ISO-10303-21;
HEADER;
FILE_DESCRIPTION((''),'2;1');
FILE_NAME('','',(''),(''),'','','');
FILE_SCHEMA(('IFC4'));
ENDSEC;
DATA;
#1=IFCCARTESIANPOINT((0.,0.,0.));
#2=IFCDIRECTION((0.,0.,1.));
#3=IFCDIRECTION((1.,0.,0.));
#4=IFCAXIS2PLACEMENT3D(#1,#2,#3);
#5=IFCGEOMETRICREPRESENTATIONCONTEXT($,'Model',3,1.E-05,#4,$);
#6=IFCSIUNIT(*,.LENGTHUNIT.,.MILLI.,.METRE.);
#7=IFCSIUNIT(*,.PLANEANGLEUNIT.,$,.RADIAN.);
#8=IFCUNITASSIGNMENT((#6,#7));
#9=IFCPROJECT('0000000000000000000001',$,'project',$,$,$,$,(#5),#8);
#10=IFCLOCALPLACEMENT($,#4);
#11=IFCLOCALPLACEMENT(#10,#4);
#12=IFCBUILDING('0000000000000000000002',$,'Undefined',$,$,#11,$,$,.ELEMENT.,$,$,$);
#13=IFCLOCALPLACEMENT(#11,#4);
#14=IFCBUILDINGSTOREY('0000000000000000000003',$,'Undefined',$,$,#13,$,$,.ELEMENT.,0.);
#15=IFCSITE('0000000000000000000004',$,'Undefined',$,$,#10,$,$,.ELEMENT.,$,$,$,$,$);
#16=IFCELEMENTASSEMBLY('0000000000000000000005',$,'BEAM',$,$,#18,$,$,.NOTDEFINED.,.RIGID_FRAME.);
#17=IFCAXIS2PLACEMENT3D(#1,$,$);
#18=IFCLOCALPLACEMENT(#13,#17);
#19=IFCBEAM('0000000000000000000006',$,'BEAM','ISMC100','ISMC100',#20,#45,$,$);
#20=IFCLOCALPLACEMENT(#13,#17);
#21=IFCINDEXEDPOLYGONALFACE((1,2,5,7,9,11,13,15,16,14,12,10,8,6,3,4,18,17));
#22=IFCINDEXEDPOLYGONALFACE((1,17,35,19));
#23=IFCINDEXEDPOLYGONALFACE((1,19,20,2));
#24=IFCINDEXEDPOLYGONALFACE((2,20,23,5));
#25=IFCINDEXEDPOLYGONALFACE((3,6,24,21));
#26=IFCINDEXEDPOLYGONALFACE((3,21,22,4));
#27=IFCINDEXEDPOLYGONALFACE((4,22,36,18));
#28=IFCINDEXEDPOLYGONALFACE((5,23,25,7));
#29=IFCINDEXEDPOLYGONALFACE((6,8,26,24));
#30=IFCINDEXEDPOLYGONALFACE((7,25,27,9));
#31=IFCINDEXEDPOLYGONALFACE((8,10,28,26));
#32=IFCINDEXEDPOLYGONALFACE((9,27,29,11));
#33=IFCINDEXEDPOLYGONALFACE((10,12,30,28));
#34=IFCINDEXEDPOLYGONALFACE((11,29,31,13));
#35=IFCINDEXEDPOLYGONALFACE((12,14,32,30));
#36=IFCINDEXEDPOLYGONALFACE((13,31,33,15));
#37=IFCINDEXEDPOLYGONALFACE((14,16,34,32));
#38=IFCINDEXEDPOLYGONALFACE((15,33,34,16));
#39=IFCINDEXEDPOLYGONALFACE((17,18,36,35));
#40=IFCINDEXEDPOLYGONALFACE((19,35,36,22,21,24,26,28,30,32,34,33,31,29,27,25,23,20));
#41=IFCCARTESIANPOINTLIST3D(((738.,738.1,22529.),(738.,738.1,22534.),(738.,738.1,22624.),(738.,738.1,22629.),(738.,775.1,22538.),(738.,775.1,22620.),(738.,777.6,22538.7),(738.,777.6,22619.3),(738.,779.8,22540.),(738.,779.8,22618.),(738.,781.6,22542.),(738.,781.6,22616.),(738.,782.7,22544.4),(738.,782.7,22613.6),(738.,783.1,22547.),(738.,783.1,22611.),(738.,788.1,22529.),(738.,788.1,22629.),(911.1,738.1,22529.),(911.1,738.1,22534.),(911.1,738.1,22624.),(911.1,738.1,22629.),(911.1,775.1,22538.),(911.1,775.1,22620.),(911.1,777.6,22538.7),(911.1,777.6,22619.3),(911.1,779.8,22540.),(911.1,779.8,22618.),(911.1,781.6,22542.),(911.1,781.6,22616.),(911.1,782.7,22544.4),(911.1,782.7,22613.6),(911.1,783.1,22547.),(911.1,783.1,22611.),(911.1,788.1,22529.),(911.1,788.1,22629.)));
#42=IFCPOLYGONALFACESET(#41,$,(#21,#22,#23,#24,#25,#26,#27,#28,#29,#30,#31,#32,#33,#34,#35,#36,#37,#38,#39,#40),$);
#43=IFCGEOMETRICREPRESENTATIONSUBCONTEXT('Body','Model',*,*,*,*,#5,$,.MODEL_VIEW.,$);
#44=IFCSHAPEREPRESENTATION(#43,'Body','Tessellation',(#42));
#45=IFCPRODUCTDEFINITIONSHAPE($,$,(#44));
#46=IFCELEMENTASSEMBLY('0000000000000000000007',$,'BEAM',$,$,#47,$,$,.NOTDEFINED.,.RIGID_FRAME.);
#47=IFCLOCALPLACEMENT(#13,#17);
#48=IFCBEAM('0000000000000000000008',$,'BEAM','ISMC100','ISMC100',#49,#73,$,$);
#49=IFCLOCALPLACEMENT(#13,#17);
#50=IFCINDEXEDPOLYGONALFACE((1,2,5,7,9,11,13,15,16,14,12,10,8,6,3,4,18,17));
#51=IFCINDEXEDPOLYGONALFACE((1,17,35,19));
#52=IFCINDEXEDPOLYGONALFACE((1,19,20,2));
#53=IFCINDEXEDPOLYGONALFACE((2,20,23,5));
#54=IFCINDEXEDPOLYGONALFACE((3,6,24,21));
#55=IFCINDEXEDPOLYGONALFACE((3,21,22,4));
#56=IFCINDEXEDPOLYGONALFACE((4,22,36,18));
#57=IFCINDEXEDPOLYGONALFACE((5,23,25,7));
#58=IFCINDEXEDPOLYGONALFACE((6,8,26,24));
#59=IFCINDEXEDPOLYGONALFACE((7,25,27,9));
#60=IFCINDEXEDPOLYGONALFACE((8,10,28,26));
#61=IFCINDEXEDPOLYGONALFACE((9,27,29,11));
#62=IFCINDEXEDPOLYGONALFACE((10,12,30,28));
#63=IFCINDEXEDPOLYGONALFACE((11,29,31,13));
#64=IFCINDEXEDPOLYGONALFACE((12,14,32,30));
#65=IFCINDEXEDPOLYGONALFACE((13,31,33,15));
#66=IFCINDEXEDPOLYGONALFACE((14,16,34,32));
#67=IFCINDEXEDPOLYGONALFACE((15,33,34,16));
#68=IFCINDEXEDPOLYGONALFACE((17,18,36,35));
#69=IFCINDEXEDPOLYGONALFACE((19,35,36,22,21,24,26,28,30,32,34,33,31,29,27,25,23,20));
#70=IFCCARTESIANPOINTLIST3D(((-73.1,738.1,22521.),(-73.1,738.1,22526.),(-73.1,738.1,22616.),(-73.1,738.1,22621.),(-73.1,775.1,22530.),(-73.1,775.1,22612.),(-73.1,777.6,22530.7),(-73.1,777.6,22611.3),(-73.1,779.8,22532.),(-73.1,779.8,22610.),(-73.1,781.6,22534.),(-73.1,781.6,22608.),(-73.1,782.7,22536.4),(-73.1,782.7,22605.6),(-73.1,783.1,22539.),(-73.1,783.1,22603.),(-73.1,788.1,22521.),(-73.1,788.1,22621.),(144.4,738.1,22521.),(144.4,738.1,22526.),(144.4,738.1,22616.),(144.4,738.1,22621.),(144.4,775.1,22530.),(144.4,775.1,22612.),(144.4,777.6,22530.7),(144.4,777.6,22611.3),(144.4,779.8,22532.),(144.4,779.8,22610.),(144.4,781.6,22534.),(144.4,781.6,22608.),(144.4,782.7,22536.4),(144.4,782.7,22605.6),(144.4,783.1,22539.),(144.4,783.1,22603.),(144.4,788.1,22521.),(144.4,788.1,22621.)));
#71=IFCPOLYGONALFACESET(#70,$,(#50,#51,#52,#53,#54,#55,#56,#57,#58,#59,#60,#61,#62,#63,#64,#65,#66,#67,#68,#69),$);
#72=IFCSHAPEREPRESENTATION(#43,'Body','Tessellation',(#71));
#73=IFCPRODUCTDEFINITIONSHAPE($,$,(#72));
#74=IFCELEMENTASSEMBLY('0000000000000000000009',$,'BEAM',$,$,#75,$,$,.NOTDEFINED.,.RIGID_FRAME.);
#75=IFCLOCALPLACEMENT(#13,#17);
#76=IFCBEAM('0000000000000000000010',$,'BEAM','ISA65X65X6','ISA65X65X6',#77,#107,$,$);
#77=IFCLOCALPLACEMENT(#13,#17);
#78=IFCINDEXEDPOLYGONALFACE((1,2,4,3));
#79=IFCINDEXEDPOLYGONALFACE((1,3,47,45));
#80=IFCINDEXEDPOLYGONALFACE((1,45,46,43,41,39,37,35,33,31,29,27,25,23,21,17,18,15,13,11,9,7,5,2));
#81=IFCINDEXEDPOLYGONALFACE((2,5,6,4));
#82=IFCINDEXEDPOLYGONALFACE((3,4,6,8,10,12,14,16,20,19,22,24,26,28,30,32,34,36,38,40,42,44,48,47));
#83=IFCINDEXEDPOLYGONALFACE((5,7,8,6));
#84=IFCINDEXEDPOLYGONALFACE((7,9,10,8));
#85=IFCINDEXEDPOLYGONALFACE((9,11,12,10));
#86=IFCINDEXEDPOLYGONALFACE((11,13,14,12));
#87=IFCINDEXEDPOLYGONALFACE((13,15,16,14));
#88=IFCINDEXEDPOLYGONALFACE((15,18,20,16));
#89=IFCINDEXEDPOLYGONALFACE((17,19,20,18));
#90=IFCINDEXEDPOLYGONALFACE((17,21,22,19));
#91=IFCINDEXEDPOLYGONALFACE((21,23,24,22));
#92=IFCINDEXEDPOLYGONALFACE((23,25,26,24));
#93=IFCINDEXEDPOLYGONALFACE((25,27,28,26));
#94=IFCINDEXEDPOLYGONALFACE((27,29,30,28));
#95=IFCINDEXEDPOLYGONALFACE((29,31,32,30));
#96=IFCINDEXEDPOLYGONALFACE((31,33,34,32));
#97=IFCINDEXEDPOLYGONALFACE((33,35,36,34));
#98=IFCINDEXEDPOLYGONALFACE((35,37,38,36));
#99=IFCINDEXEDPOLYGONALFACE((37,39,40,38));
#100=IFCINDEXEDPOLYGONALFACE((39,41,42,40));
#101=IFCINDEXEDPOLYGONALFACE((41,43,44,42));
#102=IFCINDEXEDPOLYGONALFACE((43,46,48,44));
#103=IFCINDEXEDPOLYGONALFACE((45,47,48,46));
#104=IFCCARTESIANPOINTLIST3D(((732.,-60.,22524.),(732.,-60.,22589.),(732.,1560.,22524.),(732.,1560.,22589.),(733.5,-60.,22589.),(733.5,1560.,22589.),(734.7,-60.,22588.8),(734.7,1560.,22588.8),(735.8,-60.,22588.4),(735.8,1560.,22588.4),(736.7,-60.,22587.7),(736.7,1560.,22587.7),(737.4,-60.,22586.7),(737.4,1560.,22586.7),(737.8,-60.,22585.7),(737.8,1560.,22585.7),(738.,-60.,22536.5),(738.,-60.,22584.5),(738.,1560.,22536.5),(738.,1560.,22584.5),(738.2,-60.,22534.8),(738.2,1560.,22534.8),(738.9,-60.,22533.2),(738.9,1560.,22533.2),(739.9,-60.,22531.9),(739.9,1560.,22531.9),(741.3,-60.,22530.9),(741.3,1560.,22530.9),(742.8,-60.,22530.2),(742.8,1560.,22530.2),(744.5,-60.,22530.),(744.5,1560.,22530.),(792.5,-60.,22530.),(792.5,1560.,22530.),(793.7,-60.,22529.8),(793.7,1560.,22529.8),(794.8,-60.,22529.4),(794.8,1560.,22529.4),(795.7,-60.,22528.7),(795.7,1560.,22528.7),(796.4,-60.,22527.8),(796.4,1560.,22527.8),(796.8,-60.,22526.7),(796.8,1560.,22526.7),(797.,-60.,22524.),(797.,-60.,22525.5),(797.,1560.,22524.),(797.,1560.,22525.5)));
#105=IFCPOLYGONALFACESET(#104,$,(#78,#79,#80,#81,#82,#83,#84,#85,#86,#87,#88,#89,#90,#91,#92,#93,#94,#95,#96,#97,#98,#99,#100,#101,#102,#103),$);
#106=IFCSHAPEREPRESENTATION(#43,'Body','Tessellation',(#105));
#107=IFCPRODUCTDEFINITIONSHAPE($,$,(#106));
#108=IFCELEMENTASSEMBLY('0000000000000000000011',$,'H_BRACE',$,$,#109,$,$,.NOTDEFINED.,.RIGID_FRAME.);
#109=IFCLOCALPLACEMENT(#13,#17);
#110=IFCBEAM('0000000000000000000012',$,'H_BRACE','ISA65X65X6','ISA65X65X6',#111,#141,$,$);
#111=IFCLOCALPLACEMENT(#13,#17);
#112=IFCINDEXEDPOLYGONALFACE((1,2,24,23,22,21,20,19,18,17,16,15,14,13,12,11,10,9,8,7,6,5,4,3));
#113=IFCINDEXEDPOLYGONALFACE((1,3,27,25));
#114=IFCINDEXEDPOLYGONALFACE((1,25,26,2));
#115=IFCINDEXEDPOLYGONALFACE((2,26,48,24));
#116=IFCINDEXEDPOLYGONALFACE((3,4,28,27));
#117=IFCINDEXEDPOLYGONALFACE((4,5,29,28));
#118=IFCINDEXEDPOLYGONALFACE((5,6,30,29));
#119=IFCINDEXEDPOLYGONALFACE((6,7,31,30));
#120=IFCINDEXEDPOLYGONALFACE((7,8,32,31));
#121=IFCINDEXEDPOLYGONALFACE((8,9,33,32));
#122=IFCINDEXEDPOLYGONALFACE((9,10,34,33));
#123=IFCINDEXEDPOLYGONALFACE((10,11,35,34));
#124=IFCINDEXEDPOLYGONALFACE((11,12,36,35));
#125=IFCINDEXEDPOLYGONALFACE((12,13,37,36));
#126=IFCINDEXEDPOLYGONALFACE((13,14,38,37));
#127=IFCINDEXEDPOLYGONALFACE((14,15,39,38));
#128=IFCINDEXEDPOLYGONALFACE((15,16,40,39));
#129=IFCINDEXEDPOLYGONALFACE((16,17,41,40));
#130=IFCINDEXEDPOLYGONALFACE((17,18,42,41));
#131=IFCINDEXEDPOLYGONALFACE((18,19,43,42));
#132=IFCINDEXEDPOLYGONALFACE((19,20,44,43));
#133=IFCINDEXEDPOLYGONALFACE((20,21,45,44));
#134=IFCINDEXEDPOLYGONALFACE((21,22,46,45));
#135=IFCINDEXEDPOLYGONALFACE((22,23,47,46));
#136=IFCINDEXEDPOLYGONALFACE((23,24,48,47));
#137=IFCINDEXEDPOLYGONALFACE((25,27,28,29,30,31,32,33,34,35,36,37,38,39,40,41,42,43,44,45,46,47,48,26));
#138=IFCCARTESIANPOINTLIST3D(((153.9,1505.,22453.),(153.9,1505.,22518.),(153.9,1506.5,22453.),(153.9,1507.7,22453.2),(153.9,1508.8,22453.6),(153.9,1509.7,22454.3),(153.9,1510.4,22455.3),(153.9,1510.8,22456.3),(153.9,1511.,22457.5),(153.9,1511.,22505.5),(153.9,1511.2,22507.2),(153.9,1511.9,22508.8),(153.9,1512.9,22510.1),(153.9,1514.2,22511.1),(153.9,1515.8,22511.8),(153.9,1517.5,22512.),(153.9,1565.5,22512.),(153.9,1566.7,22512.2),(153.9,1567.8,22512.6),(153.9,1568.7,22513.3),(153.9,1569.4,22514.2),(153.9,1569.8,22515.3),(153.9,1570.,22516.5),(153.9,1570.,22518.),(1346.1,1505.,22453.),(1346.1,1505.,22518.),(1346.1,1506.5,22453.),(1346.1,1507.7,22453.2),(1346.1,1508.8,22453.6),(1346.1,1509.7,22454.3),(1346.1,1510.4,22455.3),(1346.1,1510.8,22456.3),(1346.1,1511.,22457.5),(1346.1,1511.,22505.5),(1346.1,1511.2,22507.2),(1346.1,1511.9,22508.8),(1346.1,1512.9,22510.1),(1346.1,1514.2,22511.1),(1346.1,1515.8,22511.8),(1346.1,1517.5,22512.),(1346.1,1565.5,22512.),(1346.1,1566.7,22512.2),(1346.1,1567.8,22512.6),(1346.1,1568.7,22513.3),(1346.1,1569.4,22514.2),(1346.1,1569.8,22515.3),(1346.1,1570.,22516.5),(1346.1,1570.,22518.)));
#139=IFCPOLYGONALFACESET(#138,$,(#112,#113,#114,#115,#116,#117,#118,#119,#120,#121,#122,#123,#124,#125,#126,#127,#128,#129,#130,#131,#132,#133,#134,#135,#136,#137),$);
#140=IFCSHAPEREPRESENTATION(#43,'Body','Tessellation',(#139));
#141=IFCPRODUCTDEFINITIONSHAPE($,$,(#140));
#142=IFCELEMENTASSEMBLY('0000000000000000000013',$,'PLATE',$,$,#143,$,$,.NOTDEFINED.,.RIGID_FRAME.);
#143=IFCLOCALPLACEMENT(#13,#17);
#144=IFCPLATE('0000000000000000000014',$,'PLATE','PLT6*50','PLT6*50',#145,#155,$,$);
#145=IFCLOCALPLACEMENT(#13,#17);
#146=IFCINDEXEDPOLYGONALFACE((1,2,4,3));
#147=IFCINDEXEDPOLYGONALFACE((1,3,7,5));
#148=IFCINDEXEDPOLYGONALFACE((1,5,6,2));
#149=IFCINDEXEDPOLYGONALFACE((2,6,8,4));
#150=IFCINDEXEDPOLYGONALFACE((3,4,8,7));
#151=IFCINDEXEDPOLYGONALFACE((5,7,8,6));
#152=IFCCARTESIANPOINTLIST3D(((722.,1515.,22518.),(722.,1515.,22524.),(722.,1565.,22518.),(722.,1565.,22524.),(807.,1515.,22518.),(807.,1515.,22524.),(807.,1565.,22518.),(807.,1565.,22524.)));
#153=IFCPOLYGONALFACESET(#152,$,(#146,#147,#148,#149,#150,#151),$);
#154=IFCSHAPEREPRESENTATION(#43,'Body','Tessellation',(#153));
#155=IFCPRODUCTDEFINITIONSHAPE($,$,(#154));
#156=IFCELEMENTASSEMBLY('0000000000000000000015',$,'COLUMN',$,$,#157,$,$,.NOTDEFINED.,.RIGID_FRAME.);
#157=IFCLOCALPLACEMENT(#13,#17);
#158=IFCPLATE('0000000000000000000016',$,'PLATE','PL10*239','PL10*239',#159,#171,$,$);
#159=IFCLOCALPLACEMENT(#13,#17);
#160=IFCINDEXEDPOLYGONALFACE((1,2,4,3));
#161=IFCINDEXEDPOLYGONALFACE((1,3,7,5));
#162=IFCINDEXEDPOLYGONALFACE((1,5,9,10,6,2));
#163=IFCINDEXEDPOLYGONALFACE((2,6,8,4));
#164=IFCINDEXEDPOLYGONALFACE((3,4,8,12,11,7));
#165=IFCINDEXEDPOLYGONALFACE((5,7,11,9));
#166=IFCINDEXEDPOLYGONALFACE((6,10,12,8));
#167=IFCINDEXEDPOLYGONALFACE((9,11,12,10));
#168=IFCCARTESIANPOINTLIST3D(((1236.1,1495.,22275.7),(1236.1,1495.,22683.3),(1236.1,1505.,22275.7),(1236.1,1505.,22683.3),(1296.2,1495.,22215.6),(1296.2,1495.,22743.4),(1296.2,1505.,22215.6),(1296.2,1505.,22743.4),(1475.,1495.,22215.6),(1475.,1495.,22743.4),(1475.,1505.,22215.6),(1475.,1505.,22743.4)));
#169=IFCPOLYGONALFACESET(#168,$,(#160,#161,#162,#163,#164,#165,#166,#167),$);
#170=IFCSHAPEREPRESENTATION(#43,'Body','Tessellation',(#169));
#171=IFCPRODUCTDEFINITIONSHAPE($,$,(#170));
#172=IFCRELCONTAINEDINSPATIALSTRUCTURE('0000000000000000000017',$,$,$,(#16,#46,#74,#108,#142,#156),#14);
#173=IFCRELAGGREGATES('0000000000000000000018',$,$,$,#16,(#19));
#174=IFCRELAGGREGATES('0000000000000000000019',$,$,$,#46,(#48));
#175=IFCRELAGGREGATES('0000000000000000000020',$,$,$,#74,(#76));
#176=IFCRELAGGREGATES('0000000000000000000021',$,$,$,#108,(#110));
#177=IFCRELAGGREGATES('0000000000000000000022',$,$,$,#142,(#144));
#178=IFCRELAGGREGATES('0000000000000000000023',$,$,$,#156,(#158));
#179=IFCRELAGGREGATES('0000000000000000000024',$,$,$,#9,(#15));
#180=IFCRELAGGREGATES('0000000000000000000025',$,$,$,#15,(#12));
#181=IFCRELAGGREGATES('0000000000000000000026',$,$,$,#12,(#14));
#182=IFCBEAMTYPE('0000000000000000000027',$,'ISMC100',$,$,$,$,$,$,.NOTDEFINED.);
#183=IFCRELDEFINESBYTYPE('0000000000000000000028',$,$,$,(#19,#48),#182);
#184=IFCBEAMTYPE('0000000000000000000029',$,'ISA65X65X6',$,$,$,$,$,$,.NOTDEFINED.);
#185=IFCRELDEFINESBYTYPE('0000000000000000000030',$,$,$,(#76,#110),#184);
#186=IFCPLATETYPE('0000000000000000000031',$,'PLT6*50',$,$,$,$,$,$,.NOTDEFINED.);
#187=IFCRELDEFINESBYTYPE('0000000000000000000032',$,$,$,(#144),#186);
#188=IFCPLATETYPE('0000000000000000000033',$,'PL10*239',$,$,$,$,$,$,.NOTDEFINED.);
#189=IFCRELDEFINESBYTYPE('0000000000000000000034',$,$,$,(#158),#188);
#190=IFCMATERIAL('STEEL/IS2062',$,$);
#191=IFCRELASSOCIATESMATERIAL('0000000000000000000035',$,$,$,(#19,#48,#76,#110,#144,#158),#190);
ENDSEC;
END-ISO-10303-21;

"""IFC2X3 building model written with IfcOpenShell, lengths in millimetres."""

from ifc_helpers import new_model, si_unit, frame, origin_with_axes, origin_2d_with_axis, place, context, subcontext, project, spatial, polyline, l_section, u_section, outline, extrude, clip, halfspace, material, type_object, element, aggregate, save


model = new_model("IFC2X3")

# Units and contexts
model_context = context("Model", 3, precision=1e-05, world=origin_with_axes())
body_context = subcontext(model_context, "Body", "Model", "MODEL_VIEW")
ifc_project = project(units=[si_unit("LENGTHUNIT", "METRE", prefix="MILLI"), si_unit("PLANEANGLEUNIT", "RADIAN")], contexts=[model_context])

# Site, building, storey
site_placement = place(None, origin_with_axes())
site = spatial("IfcSite", under=ifc_project, at=site_placement, Name="Undefined", CompositionType="ELEMENT")
building_placement = place(site_placement, origin_with_axes())
building = spatial("IfcBuilding", under=site, at=building_placement, Name="Undefined", CompositionType="ELEMENT")
storey_placement = place(building_placement, origin_with_axes())
storey = spatial("IfcBuildingStorey", under=building, at=storey_placement, Name="Undefined", CompositionType="ELEMENT", Elevation=0.0)

# Shared definitions
ifc_material = material(Name="STEEL/IS2062")

# Element assemblies, beams
beam_type_1 = type_object("IfcBeamType", Name="ISMC100", PredefinedType="NOTDEFINED")
assembly_1_placement = place(storey_placement, origin_with_axes())
assembly_1 = element("IfcElementAssembly", 1, at=assembly_1_placement, inside=storey, Name="BEAM", AssemblyPlace="NOTDEFINED", PredefinedType="RIGID_FRAME")
beam_1_placement = place(assembly_1_placement, frame((911.1, 763.1, 22579.0), z_axis=(0.0, 0.0, -1.0), x_axis=(-1.0, 0.0, 0.0)))
beam_1 = element("IfcBeam", 2, at=beam_1_placement, type_object=beam_type_1, material=ifc_material, Name="BEAM", Description="ISMC100", ObjectType="ISMC100", context=body_context, shape_type="SweptSolid", body=[
    extrude(u_section(Depth=100.0, FlangeWidth=50.0, WebThickness=5.0, FlangeThickness=7.7, FilletRadius=9.0, FlangeSlope=0.10956, at=origin_2d_with_axis()), frame((173.1, 0.0, 0.0), z_axis=(-1.0, 0.0, 0.0), x_axis=(0.0, -1.0, 0.0)), (0.0, 0.0, 1.0), 173.1),
])
aggregate(assembly_1, [beam_1])
assembly_2_placement = place(storey_placement, origin_with_axes())
assembly_2 = element("IfcElementAssembly", 3, at=assembly_2_placement, inside=storey, Name="BEAM", AssemblyPlace="NOTDEFINED", PredefinedType="RIGID_FRAME")
beam_2_placement = place(assembly_2_placement, frame((144.4, 763.1, 22571.0), z_axis=(0.0, 0.0, -1.0), x_axis=(-1.0, 0.0, 0.0)))
beam_2 = element("IfcBeam", 4, at=beam_2_placement, type_object=beam_type_1, material=ifc_material, Name="BEAM", Description="ISMC100", ObjectType="ISMC100", context=body_context, shape_type="SweptSolid", body=[
    extrude(u_section(Depth=100.0, FlangeWidth=50.0, WebThickness=5.0, FlangeThickness=7.7, FilletRadius=9.0, FlangeSlope=0.10956, at=origin_2d_with_axis()), frame((217.6, 0.0, 0.0), z_axis=(-1.0, 0.0, 0.0), x_axis=(0.0, -1.0, 0.0)), (0.0, 0.0, 1.0), 217.6),
])
aggregate(assembly_2, [beam_2])
assembly_3_placement = place(storey_placement, origin_with_axes())
assembly_3 = element("IfcElementAssembly", 5, at=assembly_3_placement, inside=storey, Name="BEAM", AssemblyPlace="NOTDEFINED", PredefinedType="RIGID_FRAME")
beam_type_2 = type_object("IfcBeamType", Name="ISA65X65X6", PredefinedType="NOTDEFINED")
beam_3_placement = place(assembly_3_placement, frame((764.5, 1560.0, 22556.5), z_axis=(1.0, 0.0, 0.0), x_axis=(0.0, -1.0, 0.0)))
beam_3 = element("IfcBeam", 6, at=beam_3_placement, type_object=beam_type_2, material=ifc_material, Name="BEAM", Description="ISA65X65X6", ObjectType="ISA65X65X6", context=body_context, shape_type="SweptSolid", body=[
    extrude(l_section(Depth=65.0, Width=65.0, Thickness=6.0, FilletRadius=6.5, EdgeRadius=4.5, at=origin_2d_with_axis()), frame((1620.0, 0.0, 0.0), z_axis=(-1.0, 0.0, 0.0), x_axis=(0.0, -1.0, 0.0)), (0.0, 0.0, 1.0), 1620.0),
])
aggregate(assembly_3, [beam_3])
assembly_4_placement = place(storey_placement, origin_with_axes())
assembly_4 = element("IfcElementAssembly", 7, at=assembly_4_placement, inside=storey, Name="H_BRACE", AssemblyPlace="NOTDEFINED", PredefinedType="RIGID_FRAME")
beam_4_placement = place(assembly_4_placement, frame((1500.0, 1537.5, 22485.5), z_axis=(0.0, 1.0, 0.0), x_axis=(-1.0, 0.0, 0.0)))
beam_4 = element("IfcBeam", 8, at=beam_4_placement, type_object=beam_type_2, material=ifc_material, Name="H_BRACE", Description="ISA65X65X6", ObjectType="ISA65X65X6", context=body_context, shape_type="Clipping", body=[
    clip(clip(extrude(l_section(Depth=65.0, Width=65.0, Thickness=6.0, FilletRadius=6.5, EdgeRadius=4.5, at=origin_2d_with_axis()), frame((1500.0, 0.0, 0.0), z_axis=(-1.0, 0.0, 0.0), x_axis=(0.0, -1.0, 0.0)), (0.0, 0.0, 1.0), 1500.0), halfspace(frame((1346.1, 0.0, -42.5), z_axis=(-1.0, 0.0, 0.0), x_axis=(0.0, 1.0, 0.0)), True)), halfspace(frame((153.9, 0.0, -42.5), z_axis=(1.0, 0.0, 0.0), x_axis=(0.0, -1.0, 0.0)), True)),
])
aggregate(assembly_4, [beam_4])

# Element assemblies, plates
assembly_5_placement = place(storey_placement, origin_with_axes())
assembly_5 = element("IfcElementAssembly", 9, at=assembly_5_placement, inside=storey, Name="PLATE", AssemblyPlace="NOTDEFINED", PredefinedType="RIGID_FRAME")
plate_type_1 = type_object("IfcPlateType", Name="PLT6*50", PredefinedType="NOTDEFINED")
plate_1_placement = place(assembly_5_placement, frame((807.0, 1565.0, 22521.0), z_axis=(0.0, 0.0, 1.0), x_axis=(-1.0, 0.0, 0.0)))
plate_1 = element("IfcPlate", 10, at=plate_1_placement, type_object=plate_type_1, material=ifc_material, Name="PLATE", Description="PLT6*50", ObjectType="PLT6*50", context=body_context, shape_type="SweptSolid", body=[
    extrude(outline(polyline([(0.0, 0.0), (85.0, 0.0), (85.0, 50.0), (0.0, 50.0), (0.0, 0.0)])), frame((0.0, 0.0, -3.0), z_axis=(0.0, 0.0, 1.0), x_axis=(1.0, 0.0, 0.0)), (0.0, 0.0, 1.0), 6.0),
])
aggregate(assembly_5, [plate_1])
assembly_6_placement = place(storey_placement, origin_with_axes())
assembly_6 = element("IfcElementAssembly", 11, at=assembly_6_placement, inside=storey, Name="COLUMN", AssemblyPlace="NOTDEFINED", PredefinedType="RIGID_FRAME")
plate_type_2 = type_object("IfcPlateType", Name="PL10*239", PredefinedType="NOTDEFINED")
plate_2_placement = place(assembly_6_placement, frame((1475.0, 1500.0, 22743.4), z_axis=(0.0, 1.0, 0.0), x_axis=(0.0, 0.0, -1.0)))
plate_2 = element("IfcPlate", 12, at=plate_2_placement, type_object=plate_type_2, material=ifc_material, Name="PLATE", Description="PL10*239", ObjectType="PL10*239", context=body_context, shape_type="SweptSolid", body=[
    extrude(outline(polyline([(0.0, 0.0), (527.8, 0.0), (527.8, 178.8), (467.7, 238.9), (60.1, 238.9), (0.0, 178.8), (0.0, 0.0)])), frame((0.0, 0.0, -5.0), z_axis=(0.0, 0.0, 1.0), x_axis=(1.0, 0.0, 0.0)), (0.0, 0.0, 1.0), 10.0),
])
aggregate(assembly_6, [plate_2])

save(model, "model.ifc")
